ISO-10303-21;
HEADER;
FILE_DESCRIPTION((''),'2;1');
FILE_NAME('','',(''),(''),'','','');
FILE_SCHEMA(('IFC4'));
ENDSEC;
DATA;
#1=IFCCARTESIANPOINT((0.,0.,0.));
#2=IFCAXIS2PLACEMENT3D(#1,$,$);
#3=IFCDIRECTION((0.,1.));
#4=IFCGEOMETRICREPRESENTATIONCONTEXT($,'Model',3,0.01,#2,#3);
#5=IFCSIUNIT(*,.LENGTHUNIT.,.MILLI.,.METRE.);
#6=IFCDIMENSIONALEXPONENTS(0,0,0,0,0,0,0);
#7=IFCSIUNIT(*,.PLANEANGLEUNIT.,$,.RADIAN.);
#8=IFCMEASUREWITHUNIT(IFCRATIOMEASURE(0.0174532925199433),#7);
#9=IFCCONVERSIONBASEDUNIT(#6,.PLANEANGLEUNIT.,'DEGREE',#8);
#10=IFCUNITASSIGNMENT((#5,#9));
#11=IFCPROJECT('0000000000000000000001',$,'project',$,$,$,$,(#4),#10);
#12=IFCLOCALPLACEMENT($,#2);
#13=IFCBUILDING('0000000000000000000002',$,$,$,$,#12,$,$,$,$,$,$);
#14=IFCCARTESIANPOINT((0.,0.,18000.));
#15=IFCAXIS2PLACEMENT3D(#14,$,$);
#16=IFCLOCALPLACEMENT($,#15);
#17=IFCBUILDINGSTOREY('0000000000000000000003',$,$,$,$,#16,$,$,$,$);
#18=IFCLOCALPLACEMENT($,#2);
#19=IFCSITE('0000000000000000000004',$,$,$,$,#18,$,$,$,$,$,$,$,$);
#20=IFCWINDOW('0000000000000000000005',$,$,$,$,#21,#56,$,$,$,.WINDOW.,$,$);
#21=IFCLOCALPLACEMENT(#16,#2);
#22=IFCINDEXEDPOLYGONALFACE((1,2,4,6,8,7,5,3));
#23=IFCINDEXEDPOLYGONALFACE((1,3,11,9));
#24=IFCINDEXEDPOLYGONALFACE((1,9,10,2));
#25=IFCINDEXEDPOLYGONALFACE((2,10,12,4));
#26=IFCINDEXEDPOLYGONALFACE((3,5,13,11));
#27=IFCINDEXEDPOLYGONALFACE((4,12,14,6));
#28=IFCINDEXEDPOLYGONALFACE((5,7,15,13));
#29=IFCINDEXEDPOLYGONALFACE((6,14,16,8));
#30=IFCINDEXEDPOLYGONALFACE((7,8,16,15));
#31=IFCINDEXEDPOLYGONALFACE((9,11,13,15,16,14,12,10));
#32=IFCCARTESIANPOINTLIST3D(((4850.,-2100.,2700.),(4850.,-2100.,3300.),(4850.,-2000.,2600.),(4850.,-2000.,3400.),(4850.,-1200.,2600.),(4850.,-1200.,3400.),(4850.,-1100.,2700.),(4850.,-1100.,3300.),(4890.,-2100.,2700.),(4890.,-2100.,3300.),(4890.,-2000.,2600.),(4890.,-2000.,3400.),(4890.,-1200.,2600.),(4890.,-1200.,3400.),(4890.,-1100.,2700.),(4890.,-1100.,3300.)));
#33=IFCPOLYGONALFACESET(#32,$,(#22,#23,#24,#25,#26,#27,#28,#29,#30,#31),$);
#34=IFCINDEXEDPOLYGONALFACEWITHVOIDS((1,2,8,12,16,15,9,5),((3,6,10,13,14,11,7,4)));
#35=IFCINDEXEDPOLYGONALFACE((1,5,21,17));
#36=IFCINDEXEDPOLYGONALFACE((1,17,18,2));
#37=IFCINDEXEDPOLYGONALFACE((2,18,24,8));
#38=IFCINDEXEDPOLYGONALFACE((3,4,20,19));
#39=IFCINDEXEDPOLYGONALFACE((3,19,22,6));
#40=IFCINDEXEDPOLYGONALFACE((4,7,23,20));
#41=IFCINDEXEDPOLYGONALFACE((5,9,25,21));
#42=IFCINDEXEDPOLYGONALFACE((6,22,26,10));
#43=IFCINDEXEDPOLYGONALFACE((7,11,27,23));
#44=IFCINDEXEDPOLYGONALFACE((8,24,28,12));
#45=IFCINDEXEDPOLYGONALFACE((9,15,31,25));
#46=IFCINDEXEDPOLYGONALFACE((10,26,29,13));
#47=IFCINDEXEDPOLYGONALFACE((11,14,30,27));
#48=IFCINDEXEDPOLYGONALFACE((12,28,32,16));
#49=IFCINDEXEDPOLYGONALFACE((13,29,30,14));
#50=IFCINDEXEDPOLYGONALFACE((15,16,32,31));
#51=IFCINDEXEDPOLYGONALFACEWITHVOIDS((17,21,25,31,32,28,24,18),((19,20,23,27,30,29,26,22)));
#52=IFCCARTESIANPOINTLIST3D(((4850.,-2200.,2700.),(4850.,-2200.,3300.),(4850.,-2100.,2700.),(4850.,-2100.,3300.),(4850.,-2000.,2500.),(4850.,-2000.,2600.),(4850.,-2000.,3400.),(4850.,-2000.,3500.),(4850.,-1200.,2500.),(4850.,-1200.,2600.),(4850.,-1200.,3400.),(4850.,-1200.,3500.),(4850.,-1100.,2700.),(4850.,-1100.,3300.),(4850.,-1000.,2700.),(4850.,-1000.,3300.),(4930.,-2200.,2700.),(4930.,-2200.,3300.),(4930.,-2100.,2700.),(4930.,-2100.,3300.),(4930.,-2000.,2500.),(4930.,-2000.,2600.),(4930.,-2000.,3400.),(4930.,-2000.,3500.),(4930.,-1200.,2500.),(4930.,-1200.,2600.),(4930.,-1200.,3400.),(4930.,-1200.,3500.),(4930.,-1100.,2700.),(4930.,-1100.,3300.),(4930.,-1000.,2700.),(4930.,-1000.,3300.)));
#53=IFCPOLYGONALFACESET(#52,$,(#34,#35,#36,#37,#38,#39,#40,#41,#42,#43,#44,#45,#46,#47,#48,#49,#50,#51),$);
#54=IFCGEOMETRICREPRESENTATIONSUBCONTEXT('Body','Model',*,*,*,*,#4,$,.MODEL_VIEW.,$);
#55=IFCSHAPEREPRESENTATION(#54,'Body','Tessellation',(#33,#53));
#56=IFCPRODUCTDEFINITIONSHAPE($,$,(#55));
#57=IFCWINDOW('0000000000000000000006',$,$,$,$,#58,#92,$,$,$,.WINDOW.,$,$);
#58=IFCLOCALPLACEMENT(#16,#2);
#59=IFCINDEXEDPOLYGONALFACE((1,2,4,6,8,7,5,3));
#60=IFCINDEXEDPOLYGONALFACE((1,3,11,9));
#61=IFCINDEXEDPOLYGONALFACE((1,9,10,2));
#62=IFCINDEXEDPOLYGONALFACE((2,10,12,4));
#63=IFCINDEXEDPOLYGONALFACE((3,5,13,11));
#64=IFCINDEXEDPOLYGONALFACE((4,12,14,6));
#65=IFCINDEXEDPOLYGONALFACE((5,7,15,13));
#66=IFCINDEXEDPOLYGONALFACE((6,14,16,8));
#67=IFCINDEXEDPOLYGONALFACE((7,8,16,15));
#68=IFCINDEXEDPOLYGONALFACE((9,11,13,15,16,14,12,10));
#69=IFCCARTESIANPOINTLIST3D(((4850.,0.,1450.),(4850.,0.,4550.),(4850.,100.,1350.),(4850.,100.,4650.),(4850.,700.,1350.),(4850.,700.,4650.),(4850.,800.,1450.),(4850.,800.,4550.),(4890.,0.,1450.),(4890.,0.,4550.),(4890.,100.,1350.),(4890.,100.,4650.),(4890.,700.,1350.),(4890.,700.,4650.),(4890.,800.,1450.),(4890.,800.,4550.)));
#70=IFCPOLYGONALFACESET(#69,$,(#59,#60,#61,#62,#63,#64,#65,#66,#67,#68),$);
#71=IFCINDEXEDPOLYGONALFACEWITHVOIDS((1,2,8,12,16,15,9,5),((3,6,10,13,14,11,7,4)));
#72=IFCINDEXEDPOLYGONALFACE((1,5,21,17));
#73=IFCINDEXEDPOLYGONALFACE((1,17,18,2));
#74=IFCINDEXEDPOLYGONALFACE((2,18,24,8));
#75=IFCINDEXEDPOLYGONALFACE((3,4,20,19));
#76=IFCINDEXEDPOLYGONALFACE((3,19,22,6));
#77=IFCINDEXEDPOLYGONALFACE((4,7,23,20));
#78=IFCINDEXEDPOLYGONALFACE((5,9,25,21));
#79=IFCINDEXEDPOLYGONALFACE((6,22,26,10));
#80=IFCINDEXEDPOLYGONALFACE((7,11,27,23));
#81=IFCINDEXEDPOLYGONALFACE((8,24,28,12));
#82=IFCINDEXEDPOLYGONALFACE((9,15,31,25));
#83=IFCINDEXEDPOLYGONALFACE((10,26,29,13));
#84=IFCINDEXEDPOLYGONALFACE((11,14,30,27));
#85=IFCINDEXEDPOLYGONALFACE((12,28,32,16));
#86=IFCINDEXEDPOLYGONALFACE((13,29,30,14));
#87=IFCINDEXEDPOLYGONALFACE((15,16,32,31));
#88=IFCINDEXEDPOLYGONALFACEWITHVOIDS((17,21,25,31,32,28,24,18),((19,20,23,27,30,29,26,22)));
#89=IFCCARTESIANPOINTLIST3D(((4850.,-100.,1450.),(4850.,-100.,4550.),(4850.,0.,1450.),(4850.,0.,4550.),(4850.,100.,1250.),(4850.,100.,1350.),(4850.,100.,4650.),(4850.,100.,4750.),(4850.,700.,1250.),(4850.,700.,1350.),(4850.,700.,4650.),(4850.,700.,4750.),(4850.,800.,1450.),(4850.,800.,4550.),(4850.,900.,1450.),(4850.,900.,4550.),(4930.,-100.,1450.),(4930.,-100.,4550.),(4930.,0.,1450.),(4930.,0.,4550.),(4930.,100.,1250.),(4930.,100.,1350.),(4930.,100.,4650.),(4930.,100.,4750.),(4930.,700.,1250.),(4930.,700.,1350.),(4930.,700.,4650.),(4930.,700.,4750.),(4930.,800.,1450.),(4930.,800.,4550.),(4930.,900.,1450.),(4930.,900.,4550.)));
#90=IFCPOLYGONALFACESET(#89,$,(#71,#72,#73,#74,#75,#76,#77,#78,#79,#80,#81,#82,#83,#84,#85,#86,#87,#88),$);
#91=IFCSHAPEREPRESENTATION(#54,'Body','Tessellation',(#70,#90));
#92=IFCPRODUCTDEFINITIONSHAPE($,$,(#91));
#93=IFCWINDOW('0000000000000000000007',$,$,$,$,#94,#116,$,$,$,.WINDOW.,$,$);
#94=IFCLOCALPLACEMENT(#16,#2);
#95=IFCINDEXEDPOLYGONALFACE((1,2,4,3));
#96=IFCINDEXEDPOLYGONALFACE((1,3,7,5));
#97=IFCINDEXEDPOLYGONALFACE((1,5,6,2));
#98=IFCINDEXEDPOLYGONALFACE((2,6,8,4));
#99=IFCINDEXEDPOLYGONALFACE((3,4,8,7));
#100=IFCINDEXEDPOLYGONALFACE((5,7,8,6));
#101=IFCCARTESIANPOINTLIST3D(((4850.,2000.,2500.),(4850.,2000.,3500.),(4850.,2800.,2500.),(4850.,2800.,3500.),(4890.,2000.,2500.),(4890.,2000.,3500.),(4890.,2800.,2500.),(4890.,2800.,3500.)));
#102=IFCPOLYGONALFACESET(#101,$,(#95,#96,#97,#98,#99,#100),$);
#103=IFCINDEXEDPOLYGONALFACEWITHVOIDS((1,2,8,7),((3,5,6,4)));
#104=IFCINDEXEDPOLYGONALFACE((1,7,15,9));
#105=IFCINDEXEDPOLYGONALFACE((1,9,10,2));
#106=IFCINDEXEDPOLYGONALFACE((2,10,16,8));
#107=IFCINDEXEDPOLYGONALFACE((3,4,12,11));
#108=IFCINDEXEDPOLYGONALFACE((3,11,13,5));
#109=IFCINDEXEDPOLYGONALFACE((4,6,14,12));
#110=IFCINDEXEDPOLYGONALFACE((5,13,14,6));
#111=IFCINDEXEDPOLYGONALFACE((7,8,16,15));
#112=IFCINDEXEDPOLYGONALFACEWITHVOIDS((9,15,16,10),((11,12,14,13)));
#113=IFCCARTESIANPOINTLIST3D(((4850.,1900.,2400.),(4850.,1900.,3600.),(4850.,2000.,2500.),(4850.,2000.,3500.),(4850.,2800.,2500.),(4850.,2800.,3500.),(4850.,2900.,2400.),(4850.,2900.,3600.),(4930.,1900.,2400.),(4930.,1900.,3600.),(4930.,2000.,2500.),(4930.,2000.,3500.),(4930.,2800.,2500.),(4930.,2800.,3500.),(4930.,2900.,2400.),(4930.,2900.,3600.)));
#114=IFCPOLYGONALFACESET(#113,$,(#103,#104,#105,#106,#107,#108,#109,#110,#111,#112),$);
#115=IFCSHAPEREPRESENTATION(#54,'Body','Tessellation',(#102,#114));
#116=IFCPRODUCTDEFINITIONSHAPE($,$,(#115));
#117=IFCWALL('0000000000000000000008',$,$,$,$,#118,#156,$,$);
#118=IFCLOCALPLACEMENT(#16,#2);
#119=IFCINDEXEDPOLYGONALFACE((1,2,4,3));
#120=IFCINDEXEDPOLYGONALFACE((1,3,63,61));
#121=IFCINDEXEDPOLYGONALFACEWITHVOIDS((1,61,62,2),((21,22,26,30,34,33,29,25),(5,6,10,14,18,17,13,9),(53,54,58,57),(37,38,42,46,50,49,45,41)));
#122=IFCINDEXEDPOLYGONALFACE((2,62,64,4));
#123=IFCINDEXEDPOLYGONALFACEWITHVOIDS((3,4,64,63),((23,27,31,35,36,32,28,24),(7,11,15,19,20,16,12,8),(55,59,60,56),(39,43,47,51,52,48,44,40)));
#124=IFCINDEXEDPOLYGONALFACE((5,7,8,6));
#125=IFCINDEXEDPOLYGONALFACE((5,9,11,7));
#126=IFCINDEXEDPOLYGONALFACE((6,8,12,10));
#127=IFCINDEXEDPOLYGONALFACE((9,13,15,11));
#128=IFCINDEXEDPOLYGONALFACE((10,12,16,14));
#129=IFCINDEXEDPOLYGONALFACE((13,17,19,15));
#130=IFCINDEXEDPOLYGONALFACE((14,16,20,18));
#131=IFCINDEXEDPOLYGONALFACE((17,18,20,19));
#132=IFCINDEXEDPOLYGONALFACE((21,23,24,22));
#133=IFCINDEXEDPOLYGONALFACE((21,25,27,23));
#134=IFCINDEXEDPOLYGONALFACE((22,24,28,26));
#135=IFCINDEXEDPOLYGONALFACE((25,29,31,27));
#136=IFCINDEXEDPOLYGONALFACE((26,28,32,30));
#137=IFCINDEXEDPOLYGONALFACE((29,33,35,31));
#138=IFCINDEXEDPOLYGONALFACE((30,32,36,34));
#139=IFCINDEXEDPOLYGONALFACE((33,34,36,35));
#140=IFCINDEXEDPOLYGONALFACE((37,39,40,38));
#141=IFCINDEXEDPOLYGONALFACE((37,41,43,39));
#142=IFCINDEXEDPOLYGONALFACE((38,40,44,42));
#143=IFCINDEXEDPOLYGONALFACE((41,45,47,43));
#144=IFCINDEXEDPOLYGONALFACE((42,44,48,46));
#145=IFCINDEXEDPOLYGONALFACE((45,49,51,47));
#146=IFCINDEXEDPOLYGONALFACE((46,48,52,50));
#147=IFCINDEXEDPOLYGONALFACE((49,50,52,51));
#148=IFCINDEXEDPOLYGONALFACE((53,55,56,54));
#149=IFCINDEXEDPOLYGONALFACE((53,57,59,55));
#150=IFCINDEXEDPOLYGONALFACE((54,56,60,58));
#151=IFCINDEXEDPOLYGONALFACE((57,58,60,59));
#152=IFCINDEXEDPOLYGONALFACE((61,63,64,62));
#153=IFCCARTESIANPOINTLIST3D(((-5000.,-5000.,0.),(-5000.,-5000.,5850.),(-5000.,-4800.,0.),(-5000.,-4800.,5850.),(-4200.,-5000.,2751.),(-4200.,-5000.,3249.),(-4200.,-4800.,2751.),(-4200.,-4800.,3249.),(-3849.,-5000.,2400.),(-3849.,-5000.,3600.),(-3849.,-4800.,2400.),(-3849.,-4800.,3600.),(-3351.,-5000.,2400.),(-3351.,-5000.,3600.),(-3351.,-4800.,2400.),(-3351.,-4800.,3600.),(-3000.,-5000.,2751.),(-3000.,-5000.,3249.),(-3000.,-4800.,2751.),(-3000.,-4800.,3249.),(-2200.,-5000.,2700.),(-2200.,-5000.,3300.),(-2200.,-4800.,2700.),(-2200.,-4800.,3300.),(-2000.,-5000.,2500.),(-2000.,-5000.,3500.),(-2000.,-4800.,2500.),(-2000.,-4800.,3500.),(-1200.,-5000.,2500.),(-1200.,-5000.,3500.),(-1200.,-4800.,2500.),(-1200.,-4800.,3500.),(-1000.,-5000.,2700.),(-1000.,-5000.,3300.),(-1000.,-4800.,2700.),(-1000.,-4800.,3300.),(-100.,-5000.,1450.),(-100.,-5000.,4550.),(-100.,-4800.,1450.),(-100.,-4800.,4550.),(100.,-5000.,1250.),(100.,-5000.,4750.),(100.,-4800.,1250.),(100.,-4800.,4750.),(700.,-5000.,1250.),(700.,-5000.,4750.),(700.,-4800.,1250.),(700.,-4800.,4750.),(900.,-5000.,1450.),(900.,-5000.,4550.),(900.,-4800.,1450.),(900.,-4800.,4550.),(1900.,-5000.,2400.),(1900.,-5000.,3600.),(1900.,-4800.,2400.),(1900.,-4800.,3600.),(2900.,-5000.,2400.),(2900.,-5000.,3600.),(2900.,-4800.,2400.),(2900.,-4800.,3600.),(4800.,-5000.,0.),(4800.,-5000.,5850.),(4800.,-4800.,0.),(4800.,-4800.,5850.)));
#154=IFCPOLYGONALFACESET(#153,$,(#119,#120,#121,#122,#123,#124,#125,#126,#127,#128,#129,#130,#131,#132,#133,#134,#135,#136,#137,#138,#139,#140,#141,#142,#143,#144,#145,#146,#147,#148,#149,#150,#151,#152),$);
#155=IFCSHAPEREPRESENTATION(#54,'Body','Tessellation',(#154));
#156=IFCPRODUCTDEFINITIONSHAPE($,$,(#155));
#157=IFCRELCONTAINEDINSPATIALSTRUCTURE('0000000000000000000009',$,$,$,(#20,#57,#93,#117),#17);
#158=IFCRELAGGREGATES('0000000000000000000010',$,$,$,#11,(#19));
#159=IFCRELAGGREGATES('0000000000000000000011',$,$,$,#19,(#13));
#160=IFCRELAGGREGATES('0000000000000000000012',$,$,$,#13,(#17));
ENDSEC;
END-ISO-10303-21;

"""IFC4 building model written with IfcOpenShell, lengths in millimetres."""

from ifc_helpers import new_model, entity, si_unit, converted_unit, direction, frame, origin, origin_2d, place, context, subcontext, project, spatial, polyline, rectangle, outline, extrude, element, save


model = new_model("IFC4")

# Units and contexts
model_context = context("Model", 3, precision=0.01, world=origin(), true_north=direction((0.0, 1.0)))
body_context = subcontext(model_context, "Body", "Model", "MODEL_VIEW")
ifc_project = project(units=[si_unit("LENGTHUNIT", "METRE", prefix="MILLI"), converted_unit("PLANEANGLEUNIT", "DEGREE", entity("IfcRatioMeasure", 0.0174532925199433), si_unit("PLANEANGLEUNIT", "RADIAN"), dimensions=[0, 0, 0, 0, 0, 0, 0])], contexts=[model_context])

# Site, building, storey
site_placement = place(None, origin())
site = spatial("IfcSite", under=ifc_project, at=site_placement)
building_placement = place(None, origin())
building = spatial("IfcBuilding", under=site, at=building_placement)
storey_placement = place(None, frame((0.0, 0.0, 18000.0)))
storey = spatial("IfcBuildingStorey", under=building, at=storey_placement)

# Shared definitions
cartesian_point_1 = entity("IfcCartesianPoint", [-500.0, -300.0])
shared_polyline_1 = entity("IfcPolyline", [cartesian_point_1, entity("IfcCartesianPoint", [-500.0, 300.0]), entity("IfcCartesianPoint", [-400.0, 400.0]), entity("IfcCartesianPoint", [400.0, 400.0]), entity("IfcCartesianPoint", [500.0, 300.0]), entity("IfcCartesianPoint", [500.0, -300.0]), entity("IfcCartesianPoint", [400.0, -400.0]), entity("IfcCartesianPoint", [-400.0, -400.0]), cartesian_point_1])
cartesian_point_2 = entity("IfcCartesianPoint", [-400.0, -1550.0])
shared_polyline_2 = entity("IfcPolyline", [cartesian_point_2, entity("IfcCartesianPoint", [-400.0, 1550.0]), entity("IfcCartesianPoint", [-300.0, 1650.0]), entity("IfcCartesianPoint", [300.0, 1650.0]), entity("IfcCartesianPoint", [400.0, 1550.0]), entity("IfcCartesianPoint", [400.0, -1550.0]), entity("IfcCartesianPoint", [300.0, -1650.0]), entity("IfcCartesianPoint", [-300.0, -1650.0]), cartesian_point_2])
cartesian_point_3 = entity("IfcCartesianPoint", [-400.0, -500.0])
shared_polyline_3 = entity("IfcPolyline", [cartesian_point_3, entity("IfcCartesianPoint", [-400.0, 500.0]), entity("IfcCartesianPoint", [-400.0, 500.0]), entity("IfcCartesianPoint", [400.0, 500.0]), entity("IfcCartesianPoint", [400.0, 500.0]), entity("IfcCartesianPoint", [400.0, -500.0]), entity("IfcCartesianPoint", [400.0, -500.0]), entity("IfcCartesianPoint", [-400.0, -500.0]), cartesian_point_3])

# Shared definitions
wall_1_placement = place(storey_placement, frame((4900.0, -100.0, 0.0), z_axis=(0.0, 0.0, 1.0), x_axis=(0.0, 1.0, 0.0)))
window_1_placement = place(wall_1_placement, frame((-1500.0, 50.0, 3000.0)))
window_2_placement = place(wall_1_placement, frame((500.0, 50.0, 3000.0)))
window_3_placement = place(wall_1_placement, frame((2500.0, 50.0, 3000.0)))

# Windows
cartesian_point_4 = entity("IfcCartesianPoint", [-600.0, -300.0])
element("IfcWindow", 1, at=window_1_placement, inside=storey, PredefinedType="WINDOW", context=body_context, shape_type="SweptSolid", body=[
    entity("IfcExtrudedAreaSolid", entity("IfcArbitraryClosedProfileDef", "AREA", None, shared_polyline_1), entity("IfcAxis2Placement3D", entity("IfcCartesianPoint", [0.0, 0.0, 0.0]), entity("IfcDirection", [0.0, -1.0, 0.0]), entity("IfcDirection", [1.0, 0.0, 0.0])), entity("IfcDirection", [0.0, 0.0, 1.0]), 40.0),
    entity("IfcExtrudedAreaSolid", entity("IfcArbitraryProfileDefWithVoids", "AREA", None, entity("IfcPolyline", [cartesian_point_4, entity("IfcCartesianPoint", [-600.0, 300.0]), entity("IfcCartesianPoint", [-400.0, 500.0]), entity("IfcCartesianPoint", [400.0, 500.0]), entity("IfcCartesianPoint", [600.0, 300.0]), entity("IfcCartesianPoint", [600.0, -300.0]), entity("IfcCartesianPoint", [400.0, -500.0]), entity("IfcCartesianPoint", [-400.0, -500.0]), cartesian_point_4]), [shared_polyline_1]), entity("IfcAxis2Placement3D", entity("IfcCartesianPoint", [0.0, 0.0, 0.0]), entity("IfcDirection", [0.0, -1.0, 0.0]), entity("IfcDirection", [1.0, 0.0, 0.0])), entity("IfcDirection", [0.0, 0.0, 1.0]), 80.0),
])
cartesian_point_5 = entity("IfcCartesianPoint", [-500.0, -1550.0])
element("IfcWindow", 2, at=window_2_placement, inside=storey, PredefinedType="WINDOW", context=body_context, shape_type="SweptSolid", body=[
    entity("IfcExtrudedAreaSolid", entity("IfcArbitraryClosedProfileDef", "AREA", None, shared_polyline_2), entity("IfcAxis2Placement3D", entity("IfcCartesianPoint", [0.0, 0.0, 0.0]), entity("IfcDirection", [0.0, -1.0, 0.0]), entity("IfcDirection", [1.0, 0.0, 0.0])), entity("IfcDirection", [0.0, 0.0, 1.0]), 40.0),
    entity("IfcExtrudedAreaSolid", entity("IfcArbitraryProfileDefWithVoids", "AREA", None, entity("IfcPolyline", [cartesian_point_5, entity("IfcCartesianPoint", [-500.0, 1550.0]), entity("IfcCartesianPoint", [-300.0, 1750.0]), entity("IfcCartesianPoint", [300.0, 1750.0]), entity("IfcCartesianPoint", [500.0, 1550.0]), entity("IfcCartesianPoint", [500.0, -1550.0]), entity("IfcCartesianPoint", [300.0, -1750.0]), entity("IfcCartesianPoint", [-300.0, -1750.0]), cartesian_point_5]), [shared_polyline_2]), entity("IfcAxis2Placement3D", entity("IfcCartesianPoint", [0.0, 0.0, 0.0]), entity("IfcDirection", [0.0, -1.0, 0.0]), entity("IfcDirection", [1.0, 0.0, 0.0])), entity("IfcDirection", [0.0, 0.0, 1.0]), 80.0),
])
cartesian_point_6 = entity("IfcCartesianPoint", [-500.0, -600.0])
element("IfcWindow", 3, at=window_3_placement, inside=storey, PredefinedType="WINDOW", context=body_context, shape_type="SweptSolid", body=[
    entity("IfcExtrudedAreaSolid", entity("IfcArbitraryClosedProfileDef", "AREA", None, shared_polyline_3), entity("IfcAxis2Placement3D", entity("IfcCartesianPoint", [0.0, 0.0, 0.0]), entity("IfcDirection", [0.0, -1.0, 0.0]), entity("IfcDirection", [1.0, 0.0, 0.0])), entity("IfcDirection", [0.0, 0.0, 1.0]), 40.0),
    entity("IfcExtrudedAreaSolid", entity("IfcArbitraryProfileDefWithVoids", "AREA", None, entity("IfcPolyline", [cartesian_point_6, entity("IfcCartesianPoint", [-500.0, 600.0]), entity("IfcCartesianPoint", [-500.0, 600.0]), entity("IfcCartesianPoint", [500.0, 600.0]), entity("IfcCartesianPoint", [500.0, 600.0]), entity("IfcCartesianPoint", [500.0, -600.0]), entity("IfcCartesianPoint", [500.0, -600.0]), entity("IfcCartesianPoint", [-500.0, -600.0]), cartesian_point_6]), [shared_polyline_3]), entity("IfcAxis2Placement3D", entity("IfcCartesianPoint", [0.0, 0.0, 0.0]), entity("IfcDirection", [0.0, -1.0, 0.0]), entity("IfcDirection", [1.0, 0.0, 0.0])), entity("IfcDirection", [0.0, 0.0, 1.0]), 80.0),
])

# Wall, openings
wall_2_placement = place(storey_placement, frame((-100.0, -4900.0, 0.0), z_axis=(0.0, 0.0, 1.0), x_axis=(1.0, 0.0, 0.0)))
wall_2 = element("IfcWall", 4, at=wall_2_placement, inside=storey, context=body_context, shape_type="SweptSolid", body=[
    extrude(rectangle(XDim=9800.0, YDim=200.0, at=origin_2d()), origin(), (0.0, 0.0, 1.0), 5850.0),
])
window_4_placement = place(wall_2_placement, frame((-3500.0, 50.0, 3000.0)))
opening_1_placement = place(window_4_placement, frame((0.0, 50.0, 0.0)))
element("IfcOpeningElement", 5, at=opening_1_placement, cuts=wall_2, context=body_context, shape_type="SweptSolid", body=[
    extrude(outline(polyline([(-600.0, -249.0), (-600.0, 249.0), (-249.0, 600.0), (249.0, 600.0), (600.0, 249.0), (600.0, -249.0), (249.0, -600.0), (-249.0, -600.0), (-600.0, -249.0)])), frame((0.0, 0.0, 0.0), z_axis=(0.0, -1.0, 0.0), x_axis=(1.0, 0.0, 0.0)), (0.0, 0.0, 1.0), 200.0),
])
window_5_placement = place(wall_2_placement, frame((-1500.0, 50.0, 3000.0)))
opening_2_placement = place(window_5_placement, frame((0.0, 50.0, 0.0)))
element("IfcOpeningElement", 6, at=opening_2_placement, cuts=wall_2, context=body_context, shape_type="SweptSolid", body=[
    extrude(outline(polyline([(-600.0, -300.0), (-600.0, 300.0), (-400.0, 500.0), (400.0, 500.0), (600.0, 300.0), (600.0, -300.0), (400.0, -500.0), (-400.0, -500.0), (-600.0, -300.0)])), frame((0.0, 0.0, 0.0), z_axis=(0.0, -1.0, 0.0), x_axis=(1.0, 0.0, 0.0)), (0.0, 0.0, 1.0), 200.0),
])
window_6_placement = place(wall_2_placement, frame((500.0, 50.0, 3000.0)))
opening_3_placement = place(window_6_placement, frame((0.0, 50.0, 0.0)))
element("IfcOpeningElement", 7, at=opening_3_placement, cuts=wall_2, context=body_context, shape_type="SweptSolid", body=[
    extrude(outline(polyline([(-500.0, -1550.0), (-500.0, 1550.0), (-300.0, 1750.0), (300.0, 1750.0), (500.0, 1550.0), (500.0, -1550.0), (300.0, -1750.0), (-300.0, -1750.0), (-500.0, -1550.0)])), frame((0.0, 0.0, 0.0), z_axis=(0.0, -1.0, 0.0), x_axis=(1.0, 0.0, 0.0)), (0.0, 0.0, 1.0), 200.0),
])
window_7_placement = place(wall_2_placement, frame((2500.0, 50.0, 3000.0)))
opening_4_placement = place(window_7_placement, frame((0.0, 50.0, 0.0)))
element("IfcOpeningElement", 8, at=opening_4_placement, cuts=wall_2, context=body_context, shape_type="SweptSolid", body=[
    extrude(outline(polyline([(-500.0, -600.0), (-500.0, 600.0), (-500.0, 600.0), (500.0, 600.0), (500.0, 600.0), (500.0, -600.0), (500.0, -600.0), (-500.0, -600.0), (-500.0, -600.0)])), frame((0.0, 0.0, 0.0), z_axis=(0.0, -1.0, 0.0), x_axis=(1.0, 0.0, 0.0)), (0.0, 0.0, 1.0), 200.0),
])

save(model, "model.ifc")
